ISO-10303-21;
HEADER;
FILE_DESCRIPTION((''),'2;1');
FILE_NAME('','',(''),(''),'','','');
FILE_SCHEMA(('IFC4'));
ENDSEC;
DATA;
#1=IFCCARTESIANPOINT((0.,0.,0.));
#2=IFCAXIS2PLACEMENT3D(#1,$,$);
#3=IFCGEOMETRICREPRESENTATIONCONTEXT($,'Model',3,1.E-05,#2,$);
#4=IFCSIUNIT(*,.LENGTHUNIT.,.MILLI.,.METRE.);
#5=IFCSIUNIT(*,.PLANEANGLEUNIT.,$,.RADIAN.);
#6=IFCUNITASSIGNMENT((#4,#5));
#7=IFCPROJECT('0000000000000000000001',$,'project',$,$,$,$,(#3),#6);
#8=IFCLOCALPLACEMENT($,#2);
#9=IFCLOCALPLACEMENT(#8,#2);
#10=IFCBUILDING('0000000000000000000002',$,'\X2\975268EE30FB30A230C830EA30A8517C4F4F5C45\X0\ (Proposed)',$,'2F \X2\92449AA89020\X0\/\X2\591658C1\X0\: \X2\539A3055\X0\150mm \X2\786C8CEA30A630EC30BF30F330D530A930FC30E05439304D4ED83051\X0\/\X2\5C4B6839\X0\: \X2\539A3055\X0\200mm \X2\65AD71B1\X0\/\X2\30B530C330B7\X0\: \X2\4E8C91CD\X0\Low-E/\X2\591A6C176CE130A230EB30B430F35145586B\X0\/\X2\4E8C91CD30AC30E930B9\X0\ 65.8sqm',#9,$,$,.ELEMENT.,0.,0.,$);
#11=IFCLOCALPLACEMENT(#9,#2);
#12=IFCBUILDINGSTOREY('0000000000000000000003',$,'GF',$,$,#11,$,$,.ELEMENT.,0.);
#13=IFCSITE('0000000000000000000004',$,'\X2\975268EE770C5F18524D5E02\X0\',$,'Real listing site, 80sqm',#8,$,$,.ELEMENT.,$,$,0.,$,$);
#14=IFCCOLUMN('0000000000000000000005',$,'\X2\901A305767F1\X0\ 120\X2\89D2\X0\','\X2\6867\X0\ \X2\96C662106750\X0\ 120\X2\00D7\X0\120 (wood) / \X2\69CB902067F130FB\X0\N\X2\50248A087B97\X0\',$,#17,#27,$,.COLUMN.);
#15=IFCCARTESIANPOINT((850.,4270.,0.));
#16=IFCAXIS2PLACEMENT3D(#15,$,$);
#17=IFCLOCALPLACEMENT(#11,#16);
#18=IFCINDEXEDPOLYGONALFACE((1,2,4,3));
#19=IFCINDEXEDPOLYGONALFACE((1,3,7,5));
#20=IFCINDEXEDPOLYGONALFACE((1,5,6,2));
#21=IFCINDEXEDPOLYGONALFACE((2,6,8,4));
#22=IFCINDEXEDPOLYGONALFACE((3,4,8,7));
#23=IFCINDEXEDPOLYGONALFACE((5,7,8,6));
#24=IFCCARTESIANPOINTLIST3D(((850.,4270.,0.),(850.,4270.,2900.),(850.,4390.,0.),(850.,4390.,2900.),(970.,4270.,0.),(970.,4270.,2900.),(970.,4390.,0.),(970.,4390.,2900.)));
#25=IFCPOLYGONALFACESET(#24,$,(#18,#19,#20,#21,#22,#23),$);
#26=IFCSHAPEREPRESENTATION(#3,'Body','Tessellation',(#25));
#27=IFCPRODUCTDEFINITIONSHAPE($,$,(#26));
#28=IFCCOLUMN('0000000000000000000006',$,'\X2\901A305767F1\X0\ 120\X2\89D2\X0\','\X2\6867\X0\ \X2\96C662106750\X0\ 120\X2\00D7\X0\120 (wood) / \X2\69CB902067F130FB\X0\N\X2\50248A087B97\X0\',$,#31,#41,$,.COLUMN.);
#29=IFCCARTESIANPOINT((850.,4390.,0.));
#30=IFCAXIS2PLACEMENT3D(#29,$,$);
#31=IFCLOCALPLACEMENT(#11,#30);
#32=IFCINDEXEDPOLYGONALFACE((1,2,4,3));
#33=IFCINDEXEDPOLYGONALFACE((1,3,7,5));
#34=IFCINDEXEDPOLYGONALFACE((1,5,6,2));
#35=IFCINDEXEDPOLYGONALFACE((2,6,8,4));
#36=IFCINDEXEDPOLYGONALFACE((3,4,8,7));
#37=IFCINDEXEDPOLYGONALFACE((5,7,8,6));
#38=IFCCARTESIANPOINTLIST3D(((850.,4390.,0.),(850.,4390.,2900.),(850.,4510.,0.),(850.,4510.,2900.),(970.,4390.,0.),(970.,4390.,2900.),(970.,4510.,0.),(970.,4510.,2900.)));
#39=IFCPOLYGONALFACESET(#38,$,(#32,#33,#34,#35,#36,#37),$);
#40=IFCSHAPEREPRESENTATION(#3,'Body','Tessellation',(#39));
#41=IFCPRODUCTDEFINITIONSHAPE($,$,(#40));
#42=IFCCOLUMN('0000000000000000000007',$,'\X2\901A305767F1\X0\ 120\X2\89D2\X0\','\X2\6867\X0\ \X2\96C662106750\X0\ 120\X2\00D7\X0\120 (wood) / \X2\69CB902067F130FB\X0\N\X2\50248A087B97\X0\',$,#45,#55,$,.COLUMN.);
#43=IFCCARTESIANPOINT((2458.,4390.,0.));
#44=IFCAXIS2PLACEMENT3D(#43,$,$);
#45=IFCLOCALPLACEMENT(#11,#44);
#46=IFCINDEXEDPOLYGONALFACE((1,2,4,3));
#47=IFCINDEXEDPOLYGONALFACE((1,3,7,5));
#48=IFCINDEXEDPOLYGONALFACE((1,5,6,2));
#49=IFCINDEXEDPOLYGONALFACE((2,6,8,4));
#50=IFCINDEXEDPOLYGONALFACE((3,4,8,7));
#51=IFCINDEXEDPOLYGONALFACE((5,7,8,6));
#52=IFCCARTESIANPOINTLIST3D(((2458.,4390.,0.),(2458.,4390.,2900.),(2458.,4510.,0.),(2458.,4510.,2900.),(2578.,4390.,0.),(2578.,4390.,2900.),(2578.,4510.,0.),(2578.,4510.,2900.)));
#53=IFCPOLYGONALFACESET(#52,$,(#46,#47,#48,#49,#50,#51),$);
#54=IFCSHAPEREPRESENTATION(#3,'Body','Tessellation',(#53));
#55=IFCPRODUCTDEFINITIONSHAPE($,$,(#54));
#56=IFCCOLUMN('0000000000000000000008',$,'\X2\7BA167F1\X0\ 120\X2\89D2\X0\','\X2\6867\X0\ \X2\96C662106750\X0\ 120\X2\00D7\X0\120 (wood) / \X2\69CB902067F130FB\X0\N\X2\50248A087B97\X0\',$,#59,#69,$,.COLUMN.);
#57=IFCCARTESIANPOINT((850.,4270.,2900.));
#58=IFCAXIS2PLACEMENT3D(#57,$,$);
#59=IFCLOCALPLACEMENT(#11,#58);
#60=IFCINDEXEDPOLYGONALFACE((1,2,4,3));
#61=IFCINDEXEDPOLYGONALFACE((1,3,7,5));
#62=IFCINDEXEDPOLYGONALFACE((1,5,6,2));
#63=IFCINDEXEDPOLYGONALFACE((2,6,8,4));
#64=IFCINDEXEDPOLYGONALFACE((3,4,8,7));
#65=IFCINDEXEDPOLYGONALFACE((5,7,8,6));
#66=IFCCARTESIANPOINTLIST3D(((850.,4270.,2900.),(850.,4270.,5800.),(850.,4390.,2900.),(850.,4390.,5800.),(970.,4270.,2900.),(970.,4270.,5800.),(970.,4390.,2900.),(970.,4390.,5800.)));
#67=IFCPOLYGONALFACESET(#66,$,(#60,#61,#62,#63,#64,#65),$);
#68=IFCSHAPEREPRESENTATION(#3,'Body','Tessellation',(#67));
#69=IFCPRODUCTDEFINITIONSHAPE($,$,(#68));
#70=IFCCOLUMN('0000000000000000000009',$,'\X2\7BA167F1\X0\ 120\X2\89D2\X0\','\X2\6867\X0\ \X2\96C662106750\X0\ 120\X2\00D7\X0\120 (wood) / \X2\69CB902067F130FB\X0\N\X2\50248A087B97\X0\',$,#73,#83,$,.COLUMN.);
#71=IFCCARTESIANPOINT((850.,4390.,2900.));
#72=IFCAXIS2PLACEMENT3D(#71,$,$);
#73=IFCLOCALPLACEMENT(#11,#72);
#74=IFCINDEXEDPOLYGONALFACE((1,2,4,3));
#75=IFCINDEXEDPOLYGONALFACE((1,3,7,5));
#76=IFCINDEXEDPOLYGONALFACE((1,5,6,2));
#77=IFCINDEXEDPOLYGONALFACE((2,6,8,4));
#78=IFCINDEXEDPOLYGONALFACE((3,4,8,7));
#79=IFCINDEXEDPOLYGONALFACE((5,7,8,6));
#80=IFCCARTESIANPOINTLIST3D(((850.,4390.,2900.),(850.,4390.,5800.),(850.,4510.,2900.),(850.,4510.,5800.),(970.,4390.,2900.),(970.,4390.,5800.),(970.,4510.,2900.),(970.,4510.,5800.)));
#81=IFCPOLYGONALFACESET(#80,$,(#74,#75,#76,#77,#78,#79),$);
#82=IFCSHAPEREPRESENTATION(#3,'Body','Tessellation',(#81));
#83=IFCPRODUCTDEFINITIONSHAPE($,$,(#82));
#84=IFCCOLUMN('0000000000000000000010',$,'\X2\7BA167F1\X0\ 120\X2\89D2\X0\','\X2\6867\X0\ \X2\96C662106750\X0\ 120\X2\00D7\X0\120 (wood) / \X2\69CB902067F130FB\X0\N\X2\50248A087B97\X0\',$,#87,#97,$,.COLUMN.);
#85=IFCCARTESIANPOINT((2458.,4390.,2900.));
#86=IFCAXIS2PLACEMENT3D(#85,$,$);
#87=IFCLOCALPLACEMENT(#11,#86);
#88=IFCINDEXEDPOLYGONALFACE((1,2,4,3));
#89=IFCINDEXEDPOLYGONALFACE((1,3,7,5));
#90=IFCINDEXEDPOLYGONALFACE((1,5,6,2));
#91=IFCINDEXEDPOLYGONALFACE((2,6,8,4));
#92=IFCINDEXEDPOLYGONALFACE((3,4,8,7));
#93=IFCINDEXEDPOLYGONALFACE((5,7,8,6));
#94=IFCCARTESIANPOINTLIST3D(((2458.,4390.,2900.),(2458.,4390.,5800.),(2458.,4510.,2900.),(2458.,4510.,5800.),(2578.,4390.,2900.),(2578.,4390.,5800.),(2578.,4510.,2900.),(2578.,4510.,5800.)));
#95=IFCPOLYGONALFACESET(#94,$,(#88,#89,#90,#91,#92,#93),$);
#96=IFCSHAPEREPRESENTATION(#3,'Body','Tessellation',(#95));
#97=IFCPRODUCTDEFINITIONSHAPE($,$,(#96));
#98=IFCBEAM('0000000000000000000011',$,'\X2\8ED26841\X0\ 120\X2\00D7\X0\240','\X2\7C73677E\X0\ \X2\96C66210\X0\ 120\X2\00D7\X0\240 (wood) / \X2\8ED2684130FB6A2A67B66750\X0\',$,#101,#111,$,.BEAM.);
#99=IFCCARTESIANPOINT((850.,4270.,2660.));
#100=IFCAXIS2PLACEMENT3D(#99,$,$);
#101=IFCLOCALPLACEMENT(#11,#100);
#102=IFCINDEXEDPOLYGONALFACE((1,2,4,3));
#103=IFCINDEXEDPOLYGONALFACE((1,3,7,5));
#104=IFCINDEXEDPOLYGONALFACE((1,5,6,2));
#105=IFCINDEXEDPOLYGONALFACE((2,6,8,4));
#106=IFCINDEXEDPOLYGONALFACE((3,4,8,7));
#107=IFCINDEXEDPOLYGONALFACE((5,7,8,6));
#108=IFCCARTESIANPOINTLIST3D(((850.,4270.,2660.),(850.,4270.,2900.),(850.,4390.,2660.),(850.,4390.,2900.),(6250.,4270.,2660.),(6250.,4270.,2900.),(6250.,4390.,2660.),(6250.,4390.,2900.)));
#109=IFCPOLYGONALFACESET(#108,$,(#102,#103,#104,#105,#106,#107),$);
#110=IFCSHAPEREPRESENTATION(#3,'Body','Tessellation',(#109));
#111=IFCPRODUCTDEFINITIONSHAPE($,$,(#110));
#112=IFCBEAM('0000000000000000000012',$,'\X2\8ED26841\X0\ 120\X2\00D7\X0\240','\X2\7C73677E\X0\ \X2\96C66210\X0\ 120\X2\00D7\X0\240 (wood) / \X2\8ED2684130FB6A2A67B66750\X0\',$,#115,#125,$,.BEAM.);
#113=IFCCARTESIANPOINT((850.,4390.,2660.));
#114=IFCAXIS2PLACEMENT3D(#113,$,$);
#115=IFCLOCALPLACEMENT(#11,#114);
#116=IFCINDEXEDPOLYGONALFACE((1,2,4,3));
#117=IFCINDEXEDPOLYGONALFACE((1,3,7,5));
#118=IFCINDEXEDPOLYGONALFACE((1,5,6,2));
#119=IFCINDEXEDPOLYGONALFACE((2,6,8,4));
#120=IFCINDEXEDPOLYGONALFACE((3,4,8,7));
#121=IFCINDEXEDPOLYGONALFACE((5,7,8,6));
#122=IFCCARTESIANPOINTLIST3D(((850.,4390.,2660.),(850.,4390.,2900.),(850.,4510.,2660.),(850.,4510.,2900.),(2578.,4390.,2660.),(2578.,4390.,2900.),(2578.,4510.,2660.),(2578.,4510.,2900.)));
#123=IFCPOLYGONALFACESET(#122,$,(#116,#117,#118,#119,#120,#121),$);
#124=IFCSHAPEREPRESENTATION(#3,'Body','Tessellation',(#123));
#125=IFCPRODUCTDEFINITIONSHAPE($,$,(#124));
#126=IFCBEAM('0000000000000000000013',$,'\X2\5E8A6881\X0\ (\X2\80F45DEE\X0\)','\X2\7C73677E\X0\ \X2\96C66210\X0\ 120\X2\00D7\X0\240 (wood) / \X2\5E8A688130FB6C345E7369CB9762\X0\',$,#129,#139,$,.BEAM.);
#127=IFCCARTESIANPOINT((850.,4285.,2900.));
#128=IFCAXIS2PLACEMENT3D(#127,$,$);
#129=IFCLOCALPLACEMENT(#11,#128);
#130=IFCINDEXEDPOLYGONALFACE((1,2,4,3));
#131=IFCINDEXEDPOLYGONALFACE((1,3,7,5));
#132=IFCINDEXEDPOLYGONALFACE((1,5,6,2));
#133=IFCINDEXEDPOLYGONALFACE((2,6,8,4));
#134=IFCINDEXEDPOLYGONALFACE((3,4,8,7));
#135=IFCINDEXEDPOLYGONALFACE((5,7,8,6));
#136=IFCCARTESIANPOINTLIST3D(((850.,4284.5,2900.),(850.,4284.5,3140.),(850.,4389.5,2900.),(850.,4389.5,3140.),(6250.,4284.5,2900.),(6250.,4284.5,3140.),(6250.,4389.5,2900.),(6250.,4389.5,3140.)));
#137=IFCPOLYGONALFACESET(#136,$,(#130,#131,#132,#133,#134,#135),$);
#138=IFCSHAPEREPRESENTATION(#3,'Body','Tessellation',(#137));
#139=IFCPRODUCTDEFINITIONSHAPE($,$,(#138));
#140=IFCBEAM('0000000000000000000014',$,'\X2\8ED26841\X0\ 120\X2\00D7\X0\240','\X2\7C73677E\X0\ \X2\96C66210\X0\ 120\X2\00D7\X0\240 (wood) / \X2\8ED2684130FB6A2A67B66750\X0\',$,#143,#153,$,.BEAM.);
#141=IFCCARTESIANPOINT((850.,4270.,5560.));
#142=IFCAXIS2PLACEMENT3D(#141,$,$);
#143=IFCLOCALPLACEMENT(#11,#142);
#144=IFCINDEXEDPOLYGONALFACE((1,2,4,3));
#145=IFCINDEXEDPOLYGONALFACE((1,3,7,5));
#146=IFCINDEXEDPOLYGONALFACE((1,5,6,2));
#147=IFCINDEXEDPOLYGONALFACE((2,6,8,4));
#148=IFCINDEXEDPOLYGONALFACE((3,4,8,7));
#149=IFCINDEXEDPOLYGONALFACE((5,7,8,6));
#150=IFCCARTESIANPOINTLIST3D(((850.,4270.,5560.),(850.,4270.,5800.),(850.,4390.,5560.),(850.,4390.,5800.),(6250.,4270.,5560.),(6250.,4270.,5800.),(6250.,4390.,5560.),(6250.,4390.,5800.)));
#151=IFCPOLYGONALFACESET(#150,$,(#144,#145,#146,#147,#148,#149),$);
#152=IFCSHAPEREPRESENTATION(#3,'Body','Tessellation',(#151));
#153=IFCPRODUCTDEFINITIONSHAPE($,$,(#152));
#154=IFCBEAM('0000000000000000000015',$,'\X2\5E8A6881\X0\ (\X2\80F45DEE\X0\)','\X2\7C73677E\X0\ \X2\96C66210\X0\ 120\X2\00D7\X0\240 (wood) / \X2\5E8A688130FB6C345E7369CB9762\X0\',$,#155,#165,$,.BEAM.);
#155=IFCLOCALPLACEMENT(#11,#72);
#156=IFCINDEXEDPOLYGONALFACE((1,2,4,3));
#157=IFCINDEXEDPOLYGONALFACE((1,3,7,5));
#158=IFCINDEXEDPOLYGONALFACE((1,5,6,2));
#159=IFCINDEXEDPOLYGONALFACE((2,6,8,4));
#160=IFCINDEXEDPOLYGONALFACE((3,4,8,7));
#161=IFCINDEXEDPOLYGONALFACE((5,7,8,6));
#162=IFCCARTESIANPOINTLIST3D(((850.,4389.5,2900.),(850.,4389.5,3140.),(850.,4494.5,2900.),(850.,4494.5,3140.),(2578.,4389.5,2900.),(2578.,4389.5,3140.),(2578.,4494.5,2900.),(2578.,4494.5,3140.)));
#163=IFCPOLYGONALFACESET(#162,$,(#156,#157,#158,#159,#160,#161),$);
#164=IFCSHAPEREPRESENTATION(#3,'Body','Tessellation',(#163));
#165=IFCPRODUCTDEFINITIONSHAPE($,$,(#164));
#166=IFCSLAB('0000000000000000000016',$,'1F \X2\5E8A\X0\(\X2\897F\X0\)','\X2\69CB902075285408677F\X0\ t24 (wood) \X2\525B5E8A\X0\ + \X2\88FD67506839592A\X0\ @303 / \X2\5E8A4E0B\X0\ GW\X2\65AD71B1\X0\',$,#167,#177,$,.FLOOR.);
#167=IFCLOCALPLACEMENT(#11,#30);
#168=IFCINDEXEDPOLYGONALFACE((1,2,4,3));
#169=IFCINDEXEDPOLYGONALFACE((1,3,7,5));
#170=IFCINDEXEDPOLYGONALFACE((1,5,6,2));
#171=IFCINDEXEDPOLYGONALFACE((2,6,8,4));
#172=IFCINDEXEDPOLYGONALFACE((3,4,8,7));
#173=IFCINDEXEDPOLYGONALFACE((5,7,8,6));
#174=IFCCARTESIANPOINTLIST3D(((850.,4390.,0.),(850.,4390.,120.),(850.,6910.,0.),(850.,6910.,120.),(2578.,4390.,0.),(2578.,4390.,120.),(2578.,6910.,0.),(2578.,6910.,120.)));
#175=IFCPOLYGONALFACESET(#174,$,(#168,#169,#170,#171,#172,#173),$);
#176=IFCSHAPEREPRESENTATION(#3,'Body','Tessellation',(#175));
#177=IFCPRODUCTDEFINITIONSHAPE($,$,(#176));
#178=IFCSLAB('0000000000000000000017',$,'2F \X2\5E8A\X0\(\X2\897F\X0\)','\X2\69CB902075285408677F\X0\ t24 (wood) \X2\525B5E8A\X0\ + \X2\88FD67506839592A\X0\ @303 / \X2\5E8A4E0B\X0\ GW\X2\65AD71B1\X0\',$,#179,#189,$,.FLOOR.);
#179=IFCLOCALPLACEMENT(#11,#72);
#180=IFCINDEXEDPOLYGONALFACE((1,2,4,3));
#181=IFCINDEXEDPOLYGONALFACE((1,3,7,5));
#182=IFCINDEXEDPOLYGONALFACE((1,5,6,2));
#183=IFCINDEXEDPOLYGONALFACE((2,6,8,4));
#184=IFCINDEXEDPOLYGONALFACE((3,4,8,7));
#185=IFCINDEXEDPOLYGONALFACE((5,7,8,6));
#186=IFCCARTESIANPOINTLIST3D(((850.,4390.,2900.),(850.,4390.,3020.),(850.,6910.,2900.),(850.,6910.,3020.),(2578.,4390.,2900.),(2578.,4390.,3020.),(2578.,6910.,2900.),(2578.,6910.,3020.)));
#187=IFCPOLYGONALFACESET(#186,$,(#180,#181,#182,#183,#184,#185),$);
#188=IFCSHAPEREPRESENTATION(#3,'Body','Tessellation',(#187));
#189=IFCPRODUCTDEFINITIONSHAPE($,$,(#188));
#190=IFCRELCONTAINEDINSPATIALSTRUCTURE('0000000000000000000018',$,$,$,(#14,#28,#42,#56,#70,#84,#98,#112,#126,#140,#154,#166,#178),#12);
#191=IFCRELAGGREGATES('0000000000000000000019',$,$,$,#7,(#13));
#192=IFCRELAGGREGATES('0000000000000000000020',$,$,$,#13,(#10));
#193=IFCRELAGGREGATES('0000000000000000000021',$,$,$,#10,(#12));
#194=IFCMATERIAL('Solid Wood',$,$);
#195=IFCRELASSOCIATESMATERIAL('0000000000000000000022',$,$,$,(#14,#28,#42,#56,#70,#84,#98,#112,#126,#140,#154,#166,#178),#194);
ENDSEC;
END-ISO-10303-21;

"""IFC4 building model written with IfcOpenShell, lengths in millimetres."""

from ifc_helpers import new_model, si_unit, frame, frame_2d, origin, place, context, project, spatial, rectangle, extrude, material, element, save


model = new_model("IFC4")

# Units and contexts
model_context = context("Model", 3, precision=1e-05, world=origin())
ifc_project = project(units=[si_unit("LENGTHUNIT", "METRE", prefix="MILLI"), si_unit("PLANEANGLEUNIT", "RADIAN")], contexts=[model_context])

# Site, building, storey
site_placement = place(None, origin())
site = spatial("IfcSite", under=ifc_project, at=site_placement, Name="青森県弘前市", ObjectType="Real listing site, 80sqm", CompositionType="ELEMENT", RefElevation=0.0)
building_placement = place(site_placement, origin())
building = spatial("IfcBuilding", under=site, at=building_placement, Name="青森・アトリエ兼住居 (Proposed)", ObjectType="2F 鉄骨造/外壁: 厚さ150mm 硬質ウレタンフォーム吹き付け/屋根: 厚さ200mm 断熱/サッシ: 二重Low-E/多気泡アルゴン充填/二重ガラス 65.8sqm", CompositionType="ELEMENT", ElevationOfRefHeight=0.0, ElevationOfTerrain=0.0)
storey_placement = place(building_placement, origin())
storey = spatial("IfcBuildingStorey", under=building, at=storey_placement, Name="GF", CompositionType="ELEMENT", Elevation=0.0)

# Columns
ifc_material_1 = material(Name="Solid Wood")
column_1_placement = place(storey_placement, frame((850.0, 4270.0, 0.0)))
element("IfcColumn", 1, at=column_1_placement, inside=storey, material=ifc_material_1, Name="通し柱 120角", Description="桧 集成材 120×120 (wood) / 構造柱・N値計算", PredefinedType="COLUMN", context=model_context, shape_type="SweptSolid", body=[
    extrude(rectangle(XDim=120.0, YDim=120.0, at=frame_2d((60.0, 60.0))), frame((850.0, 4270.0, 0.0)), (0.0, 0.0, 1.0), 2900.0),
])
column_2_placement = place(storey_placement, frame((850.0, 4390.0, 0.0)))
element("IfcColumn", 2, at=column_2_placement, inside=storey, material=ifc_material_1, Name="通し柱 120角", Description="桧 集成材 120×120 (wood) / 構造柱・N値計算", PredefinedType="COLUMN", context=model_context, shape_type="SweptSolid", body=[
    extrude(rectangle(XDim=120.0, YDim=120.0, at=frame_2d((60.0, 60.0))), frame((850.0, 4390.0, 0.0)), (0.0, 0.0, 1.0), 2900.0),
])
column_3_placement = place(storey_placement, frame((2458.0, 4390.0, 0.0)))
element("IfcColumn", 3, at=column_3_placement, inside=storey, material=ifc_material_1, Name="通し柱 120角", Description="桧 集成材 120×120 (wood) / 構造柱・N値計算", PredefinedType="COLUMN", context=model_context, shape_type="SweptSolid", body=[
    extrude(rectangle(XDim=120.0, YDim=120.0, at=frame_2d((60.0, 60.0))), frame((2458.0, 4390.0, 0.0)), (0.0, 0.0, 1.0), 2900.0),
])
column_4_placement = place(storey_placement, frame((850.0, 4270.0, 2900.0)))
element("IfcColumn", 4, at=column_4_placement, inside=storey, material=ifc_material_1, Name="管柱 120角", Description="桧 集成材 120×120 (wood) / 構造柱・N値計算", PredefinedType="COLUMN", context=model_context, shape_type="SweptSolid", body=[
    extrude(rectangle(XDim=120.0, YDim=120.0, at=frame_2d((60.0, 60.0))), frame((850.0, 4270.0, 2900.0)), (0.0, 0.0, 1.0), 2900.0),
])
column_5_placement = place(storey_placement, frame((850.0, 4390.0, 2900.0)))
element("IfcColumn", 5, at=column_5_placement, inside=storey, material=ifc_material_1, Name="管柱 120角", Description="桧 集成材 120×120 (wood) / 構造柱・N値計算", PredefinedType="COLUMN", context=model_context, shape_type="SweptSolid", body=[
    extrude(rectangle(XDim=120.0, YDim=120.0, at=frame_2d((60.0, 60.0))), frame((850.0, 4390.0, 2900.0)), (0.0, 0.0, 1.0), 2900.0),
])
column_6_placement = place(storey_placement, frame((2458.0, 4390.0, 2900.0)))
element("IfcColumn", 6, at=column_6_placement, inside=storey, material=ifc_material_1, Name="管柱 120角", Description="桧 集成材 120×120 (wood) / 構造柱・N値計算", PredefinedType="COLUMN", context=model_context, shape_type="SweptSolid", body=[
    extrude(rectangle(XDim=120.0, YDim=120.0, at=frame_2d((60.0, 60.0))), frame((2458.0, 4390.0, 2900.0)), (0.0, 0.0, 1.0), 2900.0),
])

# Beams
beam_1_placement = place(storey_placement, frame((850.0, 4270.0, 2660.0)))
element("IfcBeam", 7, at=beam_1_placement, inside=storey, material=ifc_material_1, Name="軒桁 120×240", Description="米松 集成 120×240 (wood) / 軒桁・横架材", PredefinedType="BEAM", context=model_context, shape_type="SweptSolid", body=[
    extrude(rectangle(XDim=5400.0, YDim=120.0, at=frame_2d((2700.0, 60.0))), frame((850.0, 4270.0, 2660.0)), (0.0, 0.0, 1.0), 240.0),
])
beam_2_placement = place(storey_placement, frame((850.0, 4390.0, 2660.0)))
element("IfcBeam", 8, at=beam_2_placement, inside=storey, material=ifc_material_1, Name="軒桁 120×240", Description="米松 集成 120×240 (wood) / 軒桁・横架材", PredefinedType="BEAM", context=model_context, shape_type="SweptSolid", body=[
    extrude(rectangle(XDim=1728.0, YDim=120.0, at=frame_2d((864.0, 60.0))), frame((850.0, 4390.0, 2660.0)), (0.0, 0.0, 1.0), 240.0),
])
beam_3_placement = place(storey_placement, frame((850.0, 4285.0, 2900.0)))
element("IfcBeam", 9, at=beam_3_placement, inside=storey, material=ifc_material_1, Name="床梁 (胴差)", Description="米松 集成 120×240 (wood) / 床梁・水平構面", PredefinedType="BEAM", context=model_context, shape_type="SweptSolid", body=[
    extrude(rectangle(XDim=5400.0, YDim=105.0, at=frame_2d((2700.0, 52.0))), frame((850.0, 4285.0, 2900.0)), (0.0, 0.0, 1.0), 240.0),
])
beam_4_placement = place(storey_placement, frame((850.0, 4270.0, 5560.0)))
element("IfcBeam", 10, at=beam_4_placement, inside=storey, material=ifc_material_1, Name="軒桁 120×240", Description="米松 集成 120×240 (wood) / 軒桁・横架材", PredefinedType="BEAM", context=model_context, shape_type="SweptSolid", body=[
    extrude(rectangle(XDim=5400.0, YDim=120.0, at=frame_2d((2700.0, 60.0))), frame((850.0, 4270.0, 5560.0)), (0.0, 0.0, 1.0), 240.0),
])
beam_5_placement = place(storey_placement, frame((850.0, 4390.0, 2900.0)))
element("IfcBeam", 11, at=beam_5_placement, inside=storey, material=ifc_material_1, Name="床梁 (胴差)", Description="米松 集成 120×240 (wood) / 床梁・水平構面", PredefinedType="BEAM", context=model_context, shape_type="SweptSolid", body=[
    extrude(rectangle(XDim=1728.0, YDim=105.0, at=frame_2d((864.0, 52.0))), frame((850.0, 4390.0, 2900.0)), (0.0, 0.0, 1.0), 240.0),
])

# Slabs
slab_1_placement = place(storey_placement, frame((850.0, 4390.0, 0.0)))
element("IfcSlab", 12, at=slab_1_placement, inside=storey, material=ifc_material_1, Name="1F 床(西)", Description="構造用合板 t24 (wood) 剛床 + 製材根太 @303 / 床下 GW断熱", PredefinedType="FLOOR", context=model_context, shape_type="SweptSolid", body=[
    extrude(rectangle(XDim=1728.0, YDim=2520.0, at=frame_2d((864.0, 1260.0))), frame((850.0, 4390.0, 0.0)), (0.0, 0.0, 1.0), 120.0),
])
slab_2_placement = place(storey_placement, frame((850.0, 4390.0, 2900.0)))
element("IfcSlab", 13, at=slab_2_placement, inside=storey, material=ifc_material_1, Name="2F 床(西)", Description="構造用合板 t24 (wood) 剛床 + 製材根太 @303 / 床下 GW断熱", PredefinedType="FLOOR", context=model_context, shape_type="SweptSolid", body=[
    extrude(rectangle(XDim=1728.0, YDim=2520.0, at=frame_2d((864.0, 1260.0))), frame((850.0, 4390.0, 2900.0)), (0.0, 0.0, 1.0), 120.0),
])

save(model, "model.ifc")
